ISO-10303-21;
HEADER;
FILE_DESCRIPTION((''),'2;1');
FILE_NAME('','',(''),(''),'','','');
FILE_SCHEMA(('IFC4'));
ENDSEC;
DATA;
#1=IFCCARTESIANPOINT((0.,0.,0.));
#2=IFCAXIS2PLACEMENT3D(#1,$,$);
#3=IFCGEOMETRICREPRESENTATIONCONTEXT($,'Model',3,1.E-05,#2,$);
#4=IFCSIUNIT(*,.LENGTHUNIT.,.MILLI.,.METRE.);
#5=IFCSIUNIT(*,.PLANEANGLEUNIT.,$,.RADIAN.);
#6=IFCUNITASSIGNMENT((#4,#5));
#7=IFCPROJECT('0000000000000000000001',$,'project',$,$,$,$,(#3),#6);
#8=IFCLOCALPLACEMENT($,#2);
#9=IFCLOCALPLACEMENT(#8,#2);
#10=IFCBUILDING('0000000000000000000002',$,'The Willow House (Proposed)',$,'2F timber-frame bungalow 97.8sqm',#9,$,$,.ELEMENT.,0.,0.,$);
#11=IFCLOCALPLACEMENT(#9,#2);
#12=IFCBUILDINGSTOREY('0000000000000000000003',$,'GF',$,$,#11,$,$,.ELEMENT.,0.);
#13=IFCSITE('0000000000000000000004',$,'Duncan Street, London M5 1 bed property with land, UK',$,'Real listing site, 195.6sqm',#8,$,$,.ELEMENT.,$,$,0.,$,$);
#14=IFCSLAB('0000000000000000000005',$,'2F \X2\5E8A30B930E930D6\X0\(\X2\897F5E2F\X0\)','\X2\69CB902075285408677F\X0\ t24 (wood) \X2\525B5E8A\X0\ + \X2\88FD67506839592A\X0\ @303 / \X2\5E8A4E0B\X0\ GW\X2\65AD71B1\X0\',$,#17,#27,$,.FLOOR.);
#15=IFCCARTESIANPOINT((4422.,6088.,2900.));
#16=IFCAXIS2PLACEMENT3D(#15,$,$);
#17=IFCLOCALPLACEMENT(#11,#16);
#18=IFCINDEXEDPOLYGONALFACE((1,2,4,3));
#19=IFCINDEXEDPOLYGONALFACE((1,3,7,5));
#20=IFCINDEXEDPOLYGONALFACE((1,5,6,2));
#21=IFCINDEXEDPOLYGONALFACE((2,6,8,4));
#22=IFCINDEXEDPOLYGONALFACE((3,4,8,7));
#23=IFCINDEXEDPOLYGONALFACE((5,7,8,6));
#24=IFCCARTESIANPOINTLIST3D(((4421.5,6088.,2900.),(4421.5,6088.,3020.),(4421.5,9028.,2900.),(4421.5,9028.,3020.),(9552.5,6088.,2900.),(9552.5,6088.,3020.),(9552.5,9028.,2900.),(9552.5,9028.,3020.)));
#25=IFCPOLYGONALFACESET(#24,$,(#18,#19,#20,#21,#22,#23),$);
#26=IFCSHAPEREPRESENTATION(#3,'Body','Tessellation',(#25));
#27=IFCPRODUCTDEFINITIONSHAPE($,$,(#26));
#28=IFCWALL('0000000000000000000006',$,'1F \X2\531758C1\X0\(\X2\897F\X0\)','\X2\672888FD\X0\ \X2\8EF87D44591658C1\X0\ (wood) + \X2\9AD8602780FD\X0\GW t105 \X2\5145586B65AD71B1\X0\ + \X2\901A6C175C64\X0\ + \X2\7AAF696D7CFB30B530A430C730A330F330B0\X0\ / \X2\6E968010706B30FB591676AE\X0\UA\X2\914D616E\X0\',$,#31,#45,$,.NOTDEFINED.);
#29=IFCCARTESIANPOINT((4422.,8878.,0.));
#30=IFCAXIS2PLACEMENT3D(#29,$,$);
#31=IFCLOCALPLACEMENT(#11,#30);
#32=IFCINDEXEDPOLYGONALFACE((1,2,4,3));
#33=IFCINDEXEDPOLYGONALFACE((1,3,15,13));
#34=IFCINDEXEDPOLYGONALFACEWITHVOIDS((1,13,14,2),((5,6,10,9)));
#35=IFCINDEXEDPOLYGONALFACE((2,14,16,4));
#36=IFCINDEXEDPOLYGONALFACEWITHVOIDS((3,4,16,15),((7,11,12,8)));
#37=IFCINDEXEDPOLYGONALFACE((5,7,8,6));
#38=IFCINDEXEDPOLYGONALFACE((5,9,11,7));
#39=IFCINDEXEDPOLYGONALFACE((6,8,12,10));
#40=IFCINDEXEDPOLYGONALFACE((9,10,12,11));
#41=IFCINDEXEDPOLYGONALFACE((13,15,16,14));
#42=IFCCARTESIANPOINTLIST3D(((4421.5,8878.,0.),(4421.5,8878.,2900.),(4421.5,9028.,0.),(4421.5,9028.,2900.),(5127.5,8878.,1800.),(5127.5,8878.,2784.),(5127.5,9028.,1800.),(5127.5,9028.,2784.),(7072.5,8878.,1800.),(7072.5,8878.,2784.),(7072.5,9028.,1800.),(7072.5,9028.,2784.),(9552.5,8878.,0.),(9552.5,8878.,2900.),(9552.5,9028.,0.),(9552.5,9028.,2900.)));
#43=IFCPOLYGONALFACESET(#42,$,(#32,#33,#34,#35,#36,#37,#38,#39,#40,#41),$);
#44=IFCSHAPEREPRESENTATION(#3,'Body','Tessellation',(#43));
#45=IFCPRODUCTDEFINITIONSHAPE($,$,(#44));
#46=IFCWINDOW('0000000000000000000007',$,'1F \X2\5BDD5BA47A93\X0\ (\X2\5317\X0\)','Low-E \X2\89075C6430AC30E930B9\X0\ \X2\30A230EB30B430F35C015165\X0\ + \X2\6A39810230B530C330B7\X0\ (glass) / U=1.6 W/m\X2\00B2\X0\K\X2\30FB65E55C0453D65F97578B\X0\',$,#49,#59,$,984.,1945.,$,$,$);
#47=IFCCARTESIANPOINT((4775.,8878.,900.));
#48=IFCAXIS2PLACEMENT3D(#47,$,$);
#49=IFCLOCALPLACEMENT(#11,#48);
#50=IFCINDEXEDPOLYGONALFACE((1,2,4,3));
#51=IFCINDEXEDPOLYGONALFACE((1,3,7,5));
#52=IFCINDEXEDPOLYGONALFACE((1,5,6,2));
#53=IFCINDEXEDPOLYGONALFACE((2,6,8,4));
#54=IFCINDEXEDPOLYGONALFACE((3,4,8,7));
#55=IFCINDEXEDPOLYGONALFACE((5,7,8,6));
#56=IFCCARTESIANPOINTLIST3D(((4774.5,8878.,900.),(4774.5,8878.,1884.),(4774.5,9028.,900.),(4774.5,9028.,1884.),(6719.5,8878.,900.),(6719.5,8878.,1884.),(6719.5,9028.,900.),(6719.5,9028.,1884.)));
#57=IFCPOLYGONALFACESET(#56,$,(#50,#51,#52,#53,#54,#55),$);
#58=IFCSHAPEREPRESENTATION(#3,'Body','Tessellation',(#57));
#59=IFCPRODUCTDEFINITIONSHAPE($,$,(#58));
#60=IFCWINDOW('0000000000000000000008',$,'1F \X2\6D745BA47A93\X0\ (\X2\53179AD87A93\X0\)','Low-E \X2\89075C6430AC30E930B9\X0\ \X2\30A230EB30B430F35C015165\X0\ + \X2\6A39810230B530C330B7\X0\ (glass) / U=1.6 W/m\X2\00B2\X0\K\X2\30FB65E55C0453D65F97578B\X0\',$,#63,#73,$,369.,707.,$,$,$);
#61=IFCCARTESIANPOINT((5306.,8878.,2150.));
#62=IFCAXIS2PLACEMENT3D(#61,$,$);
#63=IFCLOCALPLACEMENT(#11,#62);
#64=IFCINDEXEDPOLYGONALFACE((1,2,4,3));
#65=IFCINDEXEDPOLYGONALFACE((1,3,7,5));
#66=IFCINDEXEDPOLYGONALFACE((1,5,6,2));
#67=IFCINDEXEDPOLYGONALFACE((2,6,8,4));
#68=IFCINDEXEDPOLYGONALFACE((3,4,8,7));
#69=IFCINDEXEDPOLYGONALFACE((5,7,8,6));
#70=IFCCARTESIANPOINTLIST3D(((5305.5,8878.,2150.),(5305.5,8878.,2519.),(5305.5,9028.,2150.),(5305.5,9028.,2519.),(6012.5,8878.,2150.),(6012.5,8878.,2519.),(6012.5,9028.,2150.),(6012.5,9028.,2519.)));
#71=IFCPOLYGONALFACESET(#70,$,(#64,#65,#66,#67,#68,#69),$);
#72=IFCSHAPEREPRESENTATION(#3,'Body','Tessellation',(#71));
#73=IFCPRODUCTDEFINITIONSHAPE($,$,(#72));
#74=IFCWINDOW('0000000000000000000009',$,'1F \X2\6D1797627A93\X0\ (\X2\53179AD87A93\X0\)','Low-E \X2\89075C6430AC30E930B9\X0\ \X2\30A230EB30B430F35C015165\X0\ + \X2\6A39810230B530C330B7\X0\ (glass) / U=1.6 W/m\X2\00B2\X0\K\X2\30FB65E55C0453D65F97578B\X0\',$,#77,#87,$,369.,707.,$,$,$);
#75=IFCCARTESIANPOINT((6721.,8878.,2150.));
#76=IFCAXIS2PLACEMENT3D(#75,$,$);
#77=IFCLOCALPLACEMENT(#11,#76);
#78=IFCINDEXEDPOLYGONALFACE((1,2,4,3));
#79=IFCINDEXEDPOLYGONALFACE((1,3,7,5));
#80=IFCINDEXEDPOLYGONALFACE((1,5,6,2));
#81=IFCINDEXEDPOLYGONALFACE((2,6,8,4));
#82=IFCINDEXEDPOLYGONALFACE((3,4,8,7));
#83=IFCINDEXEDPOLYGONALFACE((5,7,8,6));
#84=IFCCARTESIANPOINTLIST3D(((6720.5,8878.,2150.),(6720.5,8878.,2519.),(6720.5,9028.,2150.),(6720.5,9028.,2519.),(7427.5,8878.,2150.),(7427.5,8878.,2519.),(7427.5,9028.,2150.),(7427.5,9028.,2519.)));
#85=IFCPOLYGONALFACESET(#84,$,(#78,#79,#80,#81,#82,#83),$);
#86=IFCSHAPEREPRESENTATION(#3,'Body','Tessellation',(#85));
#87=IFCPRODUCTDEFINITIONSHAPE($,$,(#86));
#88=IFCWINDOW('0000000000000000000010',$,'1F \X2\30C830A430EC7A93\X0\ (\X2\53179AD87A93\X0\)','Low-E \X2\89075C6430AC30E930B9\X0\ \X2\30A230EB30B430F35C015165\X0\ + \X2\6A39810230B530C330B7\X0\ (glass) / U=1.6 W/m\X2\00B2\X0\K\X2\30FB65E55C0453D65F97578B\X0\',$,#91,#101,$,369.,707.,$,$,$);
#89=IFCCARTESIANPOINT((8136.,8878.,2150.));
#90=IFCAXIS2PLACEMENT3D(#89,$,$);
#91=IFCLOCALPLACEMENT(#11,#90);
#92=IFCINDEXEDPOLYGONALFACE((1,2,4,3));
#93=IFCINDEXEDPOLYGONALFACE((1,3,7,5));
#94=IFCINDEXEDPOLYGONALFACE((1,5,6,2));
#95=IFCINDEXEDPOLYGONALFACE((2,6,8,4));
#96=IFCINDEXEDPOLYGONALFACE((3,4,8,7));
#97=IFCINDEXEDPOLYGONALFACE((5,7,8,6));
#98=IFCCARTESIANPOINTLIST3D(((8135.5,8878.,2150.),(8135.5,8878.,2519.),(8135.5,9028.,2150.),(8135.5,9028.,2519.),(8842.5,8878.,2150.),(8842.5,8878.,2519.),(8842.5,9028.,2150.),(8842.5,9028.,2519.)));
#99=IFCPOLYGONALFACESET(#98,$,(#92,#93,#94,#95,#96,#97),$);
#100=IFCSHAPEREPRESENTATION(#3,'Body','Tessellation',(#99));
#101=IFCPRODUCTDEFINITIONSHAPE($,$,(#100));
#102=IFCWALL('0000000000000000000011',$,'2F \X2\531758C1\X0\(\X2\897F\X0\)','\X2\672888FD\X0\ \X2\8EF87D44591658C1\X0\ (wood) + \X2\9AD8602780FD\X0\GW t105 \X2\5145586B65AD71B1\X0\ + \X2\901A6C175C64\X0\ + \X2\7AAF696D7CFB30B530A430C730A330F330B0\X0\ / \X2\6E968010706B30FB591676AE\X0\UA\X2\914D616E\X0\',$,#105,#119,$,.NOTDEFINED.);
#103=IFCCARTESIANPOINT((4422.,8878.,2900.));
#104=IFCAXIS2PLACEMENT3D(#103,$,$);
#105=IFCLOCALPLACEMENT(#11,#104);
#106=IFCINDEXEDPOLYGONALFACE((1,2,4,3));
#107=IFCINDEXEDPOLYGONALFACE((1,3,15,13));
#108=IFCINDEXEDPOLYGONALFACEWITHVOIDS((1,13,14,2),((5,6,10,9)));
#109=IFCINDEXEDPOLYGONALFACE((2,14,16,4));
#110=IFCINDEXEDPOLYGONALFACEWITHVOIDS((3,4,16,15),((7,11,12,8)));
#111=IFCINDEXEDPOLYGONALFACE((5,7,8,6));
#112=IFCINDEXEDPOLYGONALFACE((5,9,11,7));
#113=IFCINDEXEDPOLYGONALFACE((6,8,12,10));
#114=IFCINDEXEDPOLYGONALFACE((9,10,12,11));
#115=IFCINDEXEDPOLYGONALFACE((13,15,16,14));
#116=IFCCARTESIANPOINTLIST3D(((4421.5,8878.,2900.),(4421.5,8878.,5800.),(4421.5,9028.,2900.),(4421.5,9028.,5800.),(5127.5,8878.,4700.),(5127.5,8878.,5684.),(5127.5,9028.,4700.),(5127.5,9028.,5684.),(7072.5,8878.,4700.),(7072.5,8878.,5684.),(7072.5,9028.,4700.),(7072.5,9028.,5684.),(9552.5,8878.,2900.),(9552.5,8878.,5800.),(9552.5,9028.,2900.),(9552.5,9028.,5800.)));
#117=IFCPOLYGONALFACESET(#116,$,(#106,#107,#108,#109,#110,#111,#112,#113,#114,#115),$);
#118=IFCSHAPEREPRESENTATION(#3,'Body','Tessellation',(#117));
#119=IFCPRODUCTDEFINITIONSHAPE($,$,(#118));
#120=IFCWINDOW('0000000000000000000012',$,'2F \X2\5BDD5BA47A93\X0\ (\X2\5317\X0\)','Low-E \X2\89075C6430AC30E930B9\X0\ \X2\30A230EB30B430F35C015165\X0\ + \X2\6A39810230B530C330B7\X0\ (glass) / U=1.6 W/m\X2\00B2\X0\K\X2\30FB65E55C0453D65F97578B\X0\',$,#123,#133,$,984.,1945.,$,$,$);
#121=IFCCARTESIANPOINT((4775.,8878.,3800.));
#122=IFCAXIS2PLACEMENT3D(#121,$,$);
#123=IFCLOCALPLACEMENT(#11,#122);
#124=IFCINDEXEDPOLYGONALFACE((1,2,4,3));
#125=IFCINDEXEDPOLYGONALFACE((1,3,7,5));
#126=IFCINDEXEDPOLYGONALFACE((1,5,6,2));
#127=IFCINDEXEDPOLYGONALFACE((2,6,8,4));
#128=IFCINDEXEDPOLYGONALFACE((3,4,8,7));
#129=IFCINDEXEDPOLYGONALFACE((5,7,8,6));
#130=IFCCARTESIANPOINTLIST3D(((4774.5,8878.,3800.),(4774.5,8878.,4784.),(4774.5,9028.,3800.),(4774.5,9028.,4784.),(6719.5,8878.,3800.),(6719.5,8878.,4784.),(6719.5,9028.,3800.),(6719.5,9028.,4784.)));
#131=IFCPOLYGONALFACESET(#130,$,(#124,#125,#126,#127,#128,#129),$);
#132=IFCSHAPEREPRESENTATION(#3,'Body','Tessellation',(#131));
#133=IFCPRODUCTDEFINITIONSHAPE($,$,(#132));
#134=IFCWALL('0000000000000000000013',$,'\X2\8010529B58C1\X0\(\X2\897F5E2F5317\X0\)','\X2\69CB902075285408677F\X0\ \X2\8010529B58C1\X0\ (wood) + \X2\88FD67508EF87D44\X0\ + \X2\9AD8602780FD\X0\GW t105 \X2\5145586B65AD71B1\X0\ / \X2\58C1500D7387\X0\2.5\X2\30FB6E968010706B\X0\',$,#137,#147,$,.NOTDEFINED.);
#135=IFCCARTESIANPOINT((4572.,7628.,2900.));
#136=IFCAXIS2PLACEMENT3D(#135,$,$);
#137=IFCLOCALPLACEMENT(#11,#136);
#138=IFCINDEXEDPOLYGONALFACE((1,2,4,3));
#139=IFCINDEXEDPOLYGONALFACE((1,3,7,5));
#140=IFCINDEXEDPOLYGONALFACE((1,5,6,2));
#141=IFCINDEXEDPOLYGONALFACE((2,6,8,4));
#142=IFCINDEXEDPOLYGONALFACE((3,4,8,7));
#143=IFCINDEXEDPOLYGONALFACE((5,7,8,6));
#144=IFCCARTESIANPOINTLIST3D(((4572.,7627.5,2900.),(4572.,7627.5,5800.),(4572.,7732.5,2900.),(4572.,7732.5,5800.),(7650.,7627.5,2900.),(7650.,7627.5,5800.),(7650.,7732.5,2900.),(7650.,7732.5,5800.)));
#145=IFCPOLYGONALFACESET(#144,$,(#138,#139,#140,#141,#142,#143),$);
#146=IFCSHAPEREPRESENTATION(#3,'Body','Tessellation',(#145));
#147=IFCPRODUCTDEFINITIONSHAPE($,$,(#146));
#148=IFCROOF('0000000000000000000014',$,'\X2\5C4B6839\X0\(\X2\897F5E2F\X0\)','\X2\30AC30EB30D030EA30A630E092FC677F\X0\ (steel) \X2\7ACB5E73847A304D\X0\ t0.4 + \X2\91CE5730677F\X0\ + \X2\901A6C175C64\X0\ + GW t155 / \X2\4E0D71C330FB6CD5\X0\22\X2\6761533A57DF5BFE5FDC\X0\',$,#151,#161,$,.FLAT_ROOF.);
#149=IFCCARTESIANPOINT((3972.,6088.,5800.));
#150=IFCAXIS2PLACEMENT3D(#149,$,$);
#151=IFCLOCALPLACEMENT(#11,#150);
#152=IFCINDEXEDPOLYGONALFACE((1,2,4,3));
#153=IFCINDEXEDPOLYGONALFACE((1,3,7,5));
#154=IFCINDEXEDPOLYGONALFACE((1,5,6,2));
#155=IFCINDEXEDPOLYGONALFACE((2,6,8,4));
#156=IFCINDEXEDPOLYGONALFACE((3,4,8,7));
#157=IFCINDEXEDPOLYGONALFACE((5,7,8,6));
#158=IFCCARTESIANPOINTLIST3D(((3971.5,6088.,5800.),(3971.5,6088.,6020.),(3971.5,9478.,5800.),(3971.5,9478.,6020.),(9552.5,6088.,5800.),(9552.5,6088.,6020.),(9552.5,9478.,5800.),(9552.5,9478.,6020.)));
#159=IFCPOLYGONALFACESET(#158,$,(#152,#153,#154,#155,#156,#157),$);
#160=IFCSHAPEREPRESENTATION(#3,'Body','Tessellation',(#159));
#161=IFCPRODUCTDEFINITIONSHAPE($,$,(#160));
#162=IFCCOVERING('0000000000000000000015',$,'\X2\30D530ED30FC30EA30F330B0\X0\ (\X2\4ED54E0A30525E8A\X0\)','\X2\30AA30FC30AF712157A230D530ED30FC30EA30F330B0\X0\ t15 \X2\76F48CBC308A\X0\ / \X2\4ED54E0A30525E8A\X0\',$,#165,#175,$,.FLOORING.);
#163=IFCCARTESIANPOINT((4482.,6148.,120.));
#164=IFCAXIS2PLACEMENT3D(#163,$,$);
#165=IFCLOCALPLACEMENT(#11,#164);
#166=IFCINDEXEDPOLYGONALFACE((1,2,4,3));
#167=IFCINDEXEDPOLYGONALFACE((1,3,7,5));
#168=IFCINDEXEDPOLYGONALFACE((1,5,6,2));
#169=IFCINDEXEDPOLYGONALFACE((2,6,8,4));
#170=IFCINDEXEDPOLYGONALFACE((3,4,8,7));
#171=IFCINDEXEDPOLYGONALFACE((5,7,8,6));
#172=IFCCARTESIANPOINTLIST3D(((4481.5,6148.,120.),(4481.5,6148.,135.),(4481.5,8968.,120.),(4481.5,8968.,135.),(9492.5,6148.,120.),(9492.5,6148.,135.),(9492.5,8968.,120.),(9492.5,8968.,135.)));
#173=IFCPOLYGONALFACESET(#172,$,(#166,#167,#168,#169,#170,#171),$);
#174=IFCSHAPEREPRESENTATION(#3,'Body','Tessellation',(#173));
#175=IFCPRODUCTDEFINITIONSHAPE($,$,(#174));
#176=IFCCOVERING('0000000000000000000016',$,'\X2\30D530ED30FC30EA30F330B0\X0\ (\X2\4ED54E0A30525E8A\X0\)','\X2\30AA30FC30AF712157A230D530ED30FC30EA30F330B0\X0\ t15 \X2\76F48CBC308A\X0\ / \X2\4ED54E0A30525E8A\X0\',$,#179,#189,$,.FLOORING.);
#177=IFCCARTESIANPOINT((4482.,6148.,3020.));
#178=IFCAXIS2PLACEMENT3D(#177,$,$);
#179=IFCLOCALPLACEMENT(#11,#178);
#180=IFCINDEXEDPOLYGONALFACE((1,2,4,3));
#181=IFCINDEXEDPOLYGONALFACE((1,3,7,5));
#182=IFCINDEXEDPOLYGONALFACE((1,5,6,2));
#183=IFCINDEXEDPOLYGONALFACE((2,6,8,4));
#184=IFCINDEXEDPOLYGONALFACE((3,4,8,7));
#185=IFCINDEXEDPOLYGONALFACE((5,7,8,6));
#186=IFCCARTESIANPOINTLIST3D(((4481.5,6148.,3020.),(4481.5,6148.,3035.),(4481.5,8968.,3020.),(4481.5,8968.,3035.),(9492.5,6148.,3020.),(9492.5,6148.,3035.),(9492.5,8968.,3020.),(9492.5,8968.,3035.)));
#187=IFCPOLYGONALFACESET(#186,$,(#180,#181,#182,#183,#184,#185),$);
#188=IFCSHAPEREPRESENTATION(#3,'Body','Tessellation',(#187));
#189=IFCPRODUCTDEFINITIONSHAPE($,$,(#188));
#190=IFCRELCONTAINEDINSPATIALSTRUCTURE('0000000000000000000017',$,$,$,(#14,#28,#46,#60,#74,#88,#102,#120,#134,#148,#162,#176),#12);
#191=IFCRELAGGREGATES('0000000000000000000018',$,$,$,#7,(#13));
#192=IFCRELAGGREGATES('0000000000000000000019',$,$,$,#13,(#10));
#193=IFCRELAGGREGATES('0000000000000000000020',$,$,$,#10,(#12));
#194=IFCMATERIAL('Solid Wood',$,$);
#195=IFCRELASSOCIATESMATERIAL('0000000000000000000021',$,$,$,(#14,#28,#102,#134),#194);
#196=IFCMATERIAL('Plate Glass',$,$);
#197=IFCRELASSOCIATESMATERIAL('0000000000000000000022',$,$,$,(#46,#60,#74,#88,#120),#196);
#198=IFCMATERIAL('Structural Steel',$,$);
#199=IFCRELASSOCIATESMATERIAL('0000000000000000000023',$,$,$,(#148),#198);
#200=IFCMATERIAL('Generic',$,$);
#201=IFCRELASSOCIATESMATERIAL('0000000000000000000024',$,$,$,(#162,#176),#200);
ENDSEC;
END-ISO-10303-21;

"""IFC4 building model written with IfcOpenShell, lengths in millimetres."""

from ifc_helpers import new_model, si_unit, frame, frame_2d, origin, place, context, project, spatial, rectangle, extrude, material, element, fill, save


model = new_model("IFC4")

# Units and contexts
model_context = context("Model", 3, precision=1e-05, world=origin())
ifc_project = project(units=[si_unit("LENGTHUNIT", "METRE", prefix="MILLI"), si_unit("PLANEANGLEUNIT", "RADIAN")], contexts=[model_context])

# Site, building, storey
site_placement = place(None, origin())
site = spatial("IfcSite", under=ifc_project, at=site_placement, Name="Duncan Street, London M5 1 bed property with land, UK", ObjectType="Real listing site, 195.6sqm", CompositionType="ELEMENT", RefElevation=0.0)
building_placement = place(site_placement, origin())
building = spatial("IfcBuilding", under=site, at=building_placement, Name="The Willow House (Proposed)", ObjectType="2F timber-frame bungalow 97.8sqm", CompositionType="ELEMENT", ElevationOfRefHeight=0.0, ElevationOfTerrain=0.0)
storey_placement = place(building_placement, origin())
storey = spatial("IfcBuildingStorey", under=building, at=storey_placement, Name="GF", CompositionType="ELEMENT", Elevation=0.0)

# Slab
ifc_material_1 = material(Name="Solid Wood")
slab_1_placement = place(storey_placement, frame((4422.0, 6088.0, 2900.0)))
element("IfcSlab", 1, at=slab_1_placement, inside=storey, material=ifc_material_1, Name="2F 床スラブ(西帯)", Description="構造用合板 t24 (wood) 剛床 + 製材根太 @303 / 床下 GW断熱", PredefinedType="FLOOR", context=model_context, shape_type="SweptSolid", body=[
    extrude(rectangle(XDim=5131.0, YDim=2940.0, at=frame_2d((2565.0, 1470.0))), frame((4422.0, 6088.0, 2900.0)), (0.0, 0.0, 1.0), 120.0),
])

# Wall, openings, windows
wall_1_placement = place(storey_placement, frame((4422.0, 8878.0, 0.0)))
wall_1 = element("IfcWall", 2, at=wall_1_placement, inside=storey, material=ifc_material_1, Name="1F 北壁(西)", Description="木製 軸組外壁 (wood) + 高性能GW t105 充填断熱 + 通気層 + 窯業系サイディング / 準耐火・外皮UA配慮", PredefinedType="NOTDEFINED", context=model_context, shape_type="SweptSolid", body=[
    extrude(rectangle(XDim=5131.0, YDim=150.0, at=frame_2d((2565.0, 75.0))), frame((4422.0, 8878.0, 0.0)), (0.0, 0.0, 1.0), 2900.0),
])
opening_1_placement = place(storey_placement, frame((4775.0, 8878.0, 900.0)))
opening_1 = element("IfcOpeningElement", 3, at=opening_1_placement, cuts=wall_1, PredefinedType="NOTDEFINED", context=model_context, shape_type="SweptSolid", body=[
    extrude(rectangle(XDim=1945.0, YDim=150.0, at=frame_2d((972.0, 75.0))), frame((4775.0, 8878.0, 900.0)), (0.0, 0.0, 1.0), 984.0),
])
opening_2_placement = place(storey_placement, frame((5306.0, 8878.0, 2150.0)))
opening_2 = element("IfcOpeningElement", 4, at=opening_2_placement, cuts=wall_1, PredefinedType="NOTDEFINED", context=model_context, shape_type="SweptSolid", body=[
    extrude(rectangle(XDim=707.0, YDim=150.0, at=frame_2d((353.0, 75.0))), frame((5306.0, 8878.0, 2150.0)), (0.0, 0.0, 1.0), 369.0),
])
opening_3_placement = place(storey_placement, frame((6721.0, 8878.0, 2150.0)))
opening_3 = element("IfcOpeningElement", 5, at=opening_3_placement, cuts=wall_1, PredefinedType="NOTDEFINED", context=model_context, shape_type="SweptSolid", body=[
    extrude(rectangle(XDim=707.0, YDim=150.0, at=frame_2d((353.0, 75.0))), frame((6721.0, 8878.0, 2150.0)), (0.0, 0.0, 1.0), 369.0),
])
opening_4_placement = place(storey_placement, frame((8136.0, 8878.0, 2150.0)))
opening_4 = element("IfcOpeningElement", 6, at=opening_4_placement, cuts=wall_1, PredefinedType="NOTDEFINED", context=model_context, shape_type="SweptSolid", body=[
    extrude(rectangle(XDim=707.0, YDim=150.0, at=frame_2d((353.0, 75.0))), frame((8136.0, 8878.0, 2150.0)), (0.0, 0.0, 1.0), 369.0),
])
ifc_material_2 = material(Name="Plate Glass")
window_1_placement = place(storey_placement, frame((4775.0, 8878.0, 900.0)))
window_1 = element("IfcWindow", 7, at=window_1_placement, inside=storey, material=ifc_material_2, Name="1F 寝室窓 (北)", Description="Low-E 複層ガラス アルゴン封入 + 樹脂サッシ (glass) / U=1.6 W/m²K・日射取得型", OverallHeight=984.0, OverallWidth=1945.0, context=model_context, shape_type="SweptSolid", body=[
    extrude(rectangle(XDim=1945.0, YDim=150.0, at=frame_2d((972.0, 75.0))), frame((4775.0, 8878.0, 900.0)), (0.0, 0.0, 1.0), 984.0),
])
fill(opening_1, window_1)
window_2_placement = place(storey_placement, frame((5306.0, 8878.0, 2150.0)))
window_2 = element("IfcWindow", 8, at=window_2_placement, inside=storey, material=ifc_material_2, Name="1F 浴室窓 (北高窓)", Description="Low-E 複層ガラス アルゴン封入 + 樹脂サッシ (glass) / U=1.6 W/m²K・日射取得型", OverallHeight=369.0, OverallWidth=707.0, context=model_context, shape_type="SweptSolid", body=[
    extrude(rectangle(XDim=707.0, YDim=150.0, at=frame_2d((353.0, 75.0))), frame((5306.0, 8878.0, 2150.0)), (0.0, 0.0, 1.0), 369.0),
])
fill(opening_2, window_2)
window_3_placement = place(storey_placement, frame((6721.0, 8878.0, 2150.0)))
window_3 = element("IfcWindow", 9, at=window_3_placement, inside=storey, material=ifc_material_2, Name="1F 洗面窓 (北高窓)", Description="Low-E 複層ガラス アルゴン封入 + 樹脂サッシ (glass) / U=1.6 W/m²K・日射取得型", OverallHeight=369.0, OverallWidth=707.0, context=model_context, shape_type="SweptSolid", body=[
    extrude(rectangle(XDim=707.0, YDim=150.0, at=frame_2d((353.0, 75.0))), frame((6721.0, 8878.0, 2150.0)), (0.0, 0.0, 1.0), 369.0),
])
fill(opening_3, window_3)
window_4_placement = place(storey_placement, frame((8136.0, 8878.0, 2150.0)))
window_4 = element("IfcWindow", 10, at=window_4_placement, inside=storey, material=ifc_material_2, Name="1F トイレ窓 (北高窓)", Description="Low-E 複層ガラス アルゴン封入 + 樹脂サッシ (glass) / U=1.6 W/m²K・日射取得型", OverallHeight=369.0, OverallWidth=707.0, context=model_context, shape_type="SweptSolid", body=[
    extrude(rectangle(XDim=707.0, YDim=150.0, at=frame_2d((353.0, 75.0))), frame((8136.0, 8878.0, 2150.0)), (0.0, 0.0, 1.0), 369.0),
])
fill(opening_4, window_4)

# Wall, opening, window
wall_2_placement = place(storey_placement, frame((4422.0, 8878.0, 2900.0)))
wall_2 = element("IfcWall", 11, at=wall_2_placement, inside=storey, material=ifc_material_1, Name="2F 北壁(西)", Description="木製 軸組外壁 (wood) + 高性能GW t105 充填断熱 + 通気層 + 窯業系サイディング / 準耐火・外皮UA配慮", PredefinedType="NOTDEFINED", context=model_context, shape_type="SweptSolid", body=[
    extrude(rectangle(XDim=5131.0, YDim=150.0, at=frame_2d((2565.0, 75.0))), frame((4422.0, 8878.0, 2900.0)), (0.0, 0.0, 1.0), 2900.0),
])
opening_5_placement = place(storey_placement, frame((4775.0, 8878.0, 3800.0)))
opening_5 = element("IfcOpeningElement", 12, at=opening_5_placement, cuts=wall_2, PredefinedType="NOTDEFINED", context=model_context, shape_type="SweptSolid", body=[
    extrude(rectangle(XDim=1945.0, YDim=150.0, at=frame_2d((972.0, 75.0))), frame((4775.0, 8878.0, 3800.0)), (0.0, 0.0, 1.0), 984.0),
])
window_5_placement = place(storey_placement, frame((4775.0, 8878.0, 3800.0)))
window_5 = element("IfcWindow", 13, at=window_5_placement, inside=storey, material=ifc_material_2, Name="2F 寝室窓 (北)", Description="Low-E 複層ガラス アルゴン封入 + 樹脂サッシ (glass) / U=1.6 W/m²K・日射取得型", OverallHeight=984.0, OverallWidth=1945.0, context=model_context, shape_type="SweptSolid", body=[
    extrude(rectangle(XDim=1945.0, YDim=150.0, at=frame_2d((972.0, 75.0))), frame((4775.0, 8878.0, 3800.0)), (0.0, 0.0, 1.0), 984.0),
])
fill(opening_5, window_5)

# Wall
wall_3_placement = place(storey_placement, frame((4572.0, 7628.0, 2900.0)))
element("IfcWall", 14, at=wall_3_placement, inside=storey, material=ifc_material_1, Name="耐力壁(西帯北)", Description="構造用合板 耐力壁 (wood) + 製材軸組 + 高性能GW t105 充填断熱 / 壁倍率2.5・準耐火", PredefinedType="NOTDEFINED", context=model_context, shape_type="SweptSolid", body=[
    extrude(rectangle(XDim=3078.0, YDim=105.0, at=frame_2d((1539.0, 52.0))), frame((4572.0, 7628.0, 2900.0)), (0.0, 0.0, 1.0), 2900.0),
])

# Roof
ifc_material_3 = material(Name="Structural Steel")
for number, where, name in (
    (15, (3972.0, 6088.0, 5800.0), "屋根(西帯)"),
):
    element("IfcRoof", number, at=place(storey_placement, frame(where)), inside=storey, material=ifc_material_3, Name=name, Description="ガルバリウム鋼板 (steel) 立平葺き t0.4 + 野地板 + 通気層 + GW t155 / 不燃・法22条区域対応", PredefinedType="FLAT_ROOF", context=model_context, shape_type="SweptSolid", body=[
        extrude(rectangle(XDim=5581.0, YDim=3390.0, at=frame_2d((2790.0, 1695.0))), frame((3972.0, 6088.0, 5800.0)), (0.0, 0.0, 1.0), 220.0),
    ])

# Coverings
ifc_material_4 = material(Name="Generic")
covering_1_placement = place(storey_placement, frame((4482.0, 6148.0, 120.0)))
element("IfcCovering", 16, at=covering_1_placement, inside=storey, material=ifc_material_4, Name="フローリング (仕上げ床)", Description="オーク無垢フローリング t15 直貼り / 仕上げ床", PredefinedType="FLOORING", context=model_context, shape_type="SweptSolid", body=[
    extrude(rectangle(XDim=5011.0, YDim=2820.0, at=frame_2d((2505.0, 1410.0))), frame((4482.0, 6148.0, 120.0)), (0.0, 0.0, 1.0), 15.0),
])
covering_2_placement = place(storey_placement, frame((4482.0, 6148.0, 3020.0)))
element("IfcCovering", 17, at=covering_2_placement, inside=storey, material=ifc_material_4, Name="フローリング (仕上げ床)", Description="オーク無垢フローリング t15 直貼り / 仕上げ床", PredefinedType="FLOORING", context=model_context, shape_type="SweptSolid", body=[
    extrude(rectangle(XDim=5011.0, YDim=2820.0, at=frame_2d((2505.0, 1410.0))), frame((4482.0, 6148.0, 3020.0)), (0.0, 0.0, 1.0), 15.0),
])

save(model, "model.ifc")
